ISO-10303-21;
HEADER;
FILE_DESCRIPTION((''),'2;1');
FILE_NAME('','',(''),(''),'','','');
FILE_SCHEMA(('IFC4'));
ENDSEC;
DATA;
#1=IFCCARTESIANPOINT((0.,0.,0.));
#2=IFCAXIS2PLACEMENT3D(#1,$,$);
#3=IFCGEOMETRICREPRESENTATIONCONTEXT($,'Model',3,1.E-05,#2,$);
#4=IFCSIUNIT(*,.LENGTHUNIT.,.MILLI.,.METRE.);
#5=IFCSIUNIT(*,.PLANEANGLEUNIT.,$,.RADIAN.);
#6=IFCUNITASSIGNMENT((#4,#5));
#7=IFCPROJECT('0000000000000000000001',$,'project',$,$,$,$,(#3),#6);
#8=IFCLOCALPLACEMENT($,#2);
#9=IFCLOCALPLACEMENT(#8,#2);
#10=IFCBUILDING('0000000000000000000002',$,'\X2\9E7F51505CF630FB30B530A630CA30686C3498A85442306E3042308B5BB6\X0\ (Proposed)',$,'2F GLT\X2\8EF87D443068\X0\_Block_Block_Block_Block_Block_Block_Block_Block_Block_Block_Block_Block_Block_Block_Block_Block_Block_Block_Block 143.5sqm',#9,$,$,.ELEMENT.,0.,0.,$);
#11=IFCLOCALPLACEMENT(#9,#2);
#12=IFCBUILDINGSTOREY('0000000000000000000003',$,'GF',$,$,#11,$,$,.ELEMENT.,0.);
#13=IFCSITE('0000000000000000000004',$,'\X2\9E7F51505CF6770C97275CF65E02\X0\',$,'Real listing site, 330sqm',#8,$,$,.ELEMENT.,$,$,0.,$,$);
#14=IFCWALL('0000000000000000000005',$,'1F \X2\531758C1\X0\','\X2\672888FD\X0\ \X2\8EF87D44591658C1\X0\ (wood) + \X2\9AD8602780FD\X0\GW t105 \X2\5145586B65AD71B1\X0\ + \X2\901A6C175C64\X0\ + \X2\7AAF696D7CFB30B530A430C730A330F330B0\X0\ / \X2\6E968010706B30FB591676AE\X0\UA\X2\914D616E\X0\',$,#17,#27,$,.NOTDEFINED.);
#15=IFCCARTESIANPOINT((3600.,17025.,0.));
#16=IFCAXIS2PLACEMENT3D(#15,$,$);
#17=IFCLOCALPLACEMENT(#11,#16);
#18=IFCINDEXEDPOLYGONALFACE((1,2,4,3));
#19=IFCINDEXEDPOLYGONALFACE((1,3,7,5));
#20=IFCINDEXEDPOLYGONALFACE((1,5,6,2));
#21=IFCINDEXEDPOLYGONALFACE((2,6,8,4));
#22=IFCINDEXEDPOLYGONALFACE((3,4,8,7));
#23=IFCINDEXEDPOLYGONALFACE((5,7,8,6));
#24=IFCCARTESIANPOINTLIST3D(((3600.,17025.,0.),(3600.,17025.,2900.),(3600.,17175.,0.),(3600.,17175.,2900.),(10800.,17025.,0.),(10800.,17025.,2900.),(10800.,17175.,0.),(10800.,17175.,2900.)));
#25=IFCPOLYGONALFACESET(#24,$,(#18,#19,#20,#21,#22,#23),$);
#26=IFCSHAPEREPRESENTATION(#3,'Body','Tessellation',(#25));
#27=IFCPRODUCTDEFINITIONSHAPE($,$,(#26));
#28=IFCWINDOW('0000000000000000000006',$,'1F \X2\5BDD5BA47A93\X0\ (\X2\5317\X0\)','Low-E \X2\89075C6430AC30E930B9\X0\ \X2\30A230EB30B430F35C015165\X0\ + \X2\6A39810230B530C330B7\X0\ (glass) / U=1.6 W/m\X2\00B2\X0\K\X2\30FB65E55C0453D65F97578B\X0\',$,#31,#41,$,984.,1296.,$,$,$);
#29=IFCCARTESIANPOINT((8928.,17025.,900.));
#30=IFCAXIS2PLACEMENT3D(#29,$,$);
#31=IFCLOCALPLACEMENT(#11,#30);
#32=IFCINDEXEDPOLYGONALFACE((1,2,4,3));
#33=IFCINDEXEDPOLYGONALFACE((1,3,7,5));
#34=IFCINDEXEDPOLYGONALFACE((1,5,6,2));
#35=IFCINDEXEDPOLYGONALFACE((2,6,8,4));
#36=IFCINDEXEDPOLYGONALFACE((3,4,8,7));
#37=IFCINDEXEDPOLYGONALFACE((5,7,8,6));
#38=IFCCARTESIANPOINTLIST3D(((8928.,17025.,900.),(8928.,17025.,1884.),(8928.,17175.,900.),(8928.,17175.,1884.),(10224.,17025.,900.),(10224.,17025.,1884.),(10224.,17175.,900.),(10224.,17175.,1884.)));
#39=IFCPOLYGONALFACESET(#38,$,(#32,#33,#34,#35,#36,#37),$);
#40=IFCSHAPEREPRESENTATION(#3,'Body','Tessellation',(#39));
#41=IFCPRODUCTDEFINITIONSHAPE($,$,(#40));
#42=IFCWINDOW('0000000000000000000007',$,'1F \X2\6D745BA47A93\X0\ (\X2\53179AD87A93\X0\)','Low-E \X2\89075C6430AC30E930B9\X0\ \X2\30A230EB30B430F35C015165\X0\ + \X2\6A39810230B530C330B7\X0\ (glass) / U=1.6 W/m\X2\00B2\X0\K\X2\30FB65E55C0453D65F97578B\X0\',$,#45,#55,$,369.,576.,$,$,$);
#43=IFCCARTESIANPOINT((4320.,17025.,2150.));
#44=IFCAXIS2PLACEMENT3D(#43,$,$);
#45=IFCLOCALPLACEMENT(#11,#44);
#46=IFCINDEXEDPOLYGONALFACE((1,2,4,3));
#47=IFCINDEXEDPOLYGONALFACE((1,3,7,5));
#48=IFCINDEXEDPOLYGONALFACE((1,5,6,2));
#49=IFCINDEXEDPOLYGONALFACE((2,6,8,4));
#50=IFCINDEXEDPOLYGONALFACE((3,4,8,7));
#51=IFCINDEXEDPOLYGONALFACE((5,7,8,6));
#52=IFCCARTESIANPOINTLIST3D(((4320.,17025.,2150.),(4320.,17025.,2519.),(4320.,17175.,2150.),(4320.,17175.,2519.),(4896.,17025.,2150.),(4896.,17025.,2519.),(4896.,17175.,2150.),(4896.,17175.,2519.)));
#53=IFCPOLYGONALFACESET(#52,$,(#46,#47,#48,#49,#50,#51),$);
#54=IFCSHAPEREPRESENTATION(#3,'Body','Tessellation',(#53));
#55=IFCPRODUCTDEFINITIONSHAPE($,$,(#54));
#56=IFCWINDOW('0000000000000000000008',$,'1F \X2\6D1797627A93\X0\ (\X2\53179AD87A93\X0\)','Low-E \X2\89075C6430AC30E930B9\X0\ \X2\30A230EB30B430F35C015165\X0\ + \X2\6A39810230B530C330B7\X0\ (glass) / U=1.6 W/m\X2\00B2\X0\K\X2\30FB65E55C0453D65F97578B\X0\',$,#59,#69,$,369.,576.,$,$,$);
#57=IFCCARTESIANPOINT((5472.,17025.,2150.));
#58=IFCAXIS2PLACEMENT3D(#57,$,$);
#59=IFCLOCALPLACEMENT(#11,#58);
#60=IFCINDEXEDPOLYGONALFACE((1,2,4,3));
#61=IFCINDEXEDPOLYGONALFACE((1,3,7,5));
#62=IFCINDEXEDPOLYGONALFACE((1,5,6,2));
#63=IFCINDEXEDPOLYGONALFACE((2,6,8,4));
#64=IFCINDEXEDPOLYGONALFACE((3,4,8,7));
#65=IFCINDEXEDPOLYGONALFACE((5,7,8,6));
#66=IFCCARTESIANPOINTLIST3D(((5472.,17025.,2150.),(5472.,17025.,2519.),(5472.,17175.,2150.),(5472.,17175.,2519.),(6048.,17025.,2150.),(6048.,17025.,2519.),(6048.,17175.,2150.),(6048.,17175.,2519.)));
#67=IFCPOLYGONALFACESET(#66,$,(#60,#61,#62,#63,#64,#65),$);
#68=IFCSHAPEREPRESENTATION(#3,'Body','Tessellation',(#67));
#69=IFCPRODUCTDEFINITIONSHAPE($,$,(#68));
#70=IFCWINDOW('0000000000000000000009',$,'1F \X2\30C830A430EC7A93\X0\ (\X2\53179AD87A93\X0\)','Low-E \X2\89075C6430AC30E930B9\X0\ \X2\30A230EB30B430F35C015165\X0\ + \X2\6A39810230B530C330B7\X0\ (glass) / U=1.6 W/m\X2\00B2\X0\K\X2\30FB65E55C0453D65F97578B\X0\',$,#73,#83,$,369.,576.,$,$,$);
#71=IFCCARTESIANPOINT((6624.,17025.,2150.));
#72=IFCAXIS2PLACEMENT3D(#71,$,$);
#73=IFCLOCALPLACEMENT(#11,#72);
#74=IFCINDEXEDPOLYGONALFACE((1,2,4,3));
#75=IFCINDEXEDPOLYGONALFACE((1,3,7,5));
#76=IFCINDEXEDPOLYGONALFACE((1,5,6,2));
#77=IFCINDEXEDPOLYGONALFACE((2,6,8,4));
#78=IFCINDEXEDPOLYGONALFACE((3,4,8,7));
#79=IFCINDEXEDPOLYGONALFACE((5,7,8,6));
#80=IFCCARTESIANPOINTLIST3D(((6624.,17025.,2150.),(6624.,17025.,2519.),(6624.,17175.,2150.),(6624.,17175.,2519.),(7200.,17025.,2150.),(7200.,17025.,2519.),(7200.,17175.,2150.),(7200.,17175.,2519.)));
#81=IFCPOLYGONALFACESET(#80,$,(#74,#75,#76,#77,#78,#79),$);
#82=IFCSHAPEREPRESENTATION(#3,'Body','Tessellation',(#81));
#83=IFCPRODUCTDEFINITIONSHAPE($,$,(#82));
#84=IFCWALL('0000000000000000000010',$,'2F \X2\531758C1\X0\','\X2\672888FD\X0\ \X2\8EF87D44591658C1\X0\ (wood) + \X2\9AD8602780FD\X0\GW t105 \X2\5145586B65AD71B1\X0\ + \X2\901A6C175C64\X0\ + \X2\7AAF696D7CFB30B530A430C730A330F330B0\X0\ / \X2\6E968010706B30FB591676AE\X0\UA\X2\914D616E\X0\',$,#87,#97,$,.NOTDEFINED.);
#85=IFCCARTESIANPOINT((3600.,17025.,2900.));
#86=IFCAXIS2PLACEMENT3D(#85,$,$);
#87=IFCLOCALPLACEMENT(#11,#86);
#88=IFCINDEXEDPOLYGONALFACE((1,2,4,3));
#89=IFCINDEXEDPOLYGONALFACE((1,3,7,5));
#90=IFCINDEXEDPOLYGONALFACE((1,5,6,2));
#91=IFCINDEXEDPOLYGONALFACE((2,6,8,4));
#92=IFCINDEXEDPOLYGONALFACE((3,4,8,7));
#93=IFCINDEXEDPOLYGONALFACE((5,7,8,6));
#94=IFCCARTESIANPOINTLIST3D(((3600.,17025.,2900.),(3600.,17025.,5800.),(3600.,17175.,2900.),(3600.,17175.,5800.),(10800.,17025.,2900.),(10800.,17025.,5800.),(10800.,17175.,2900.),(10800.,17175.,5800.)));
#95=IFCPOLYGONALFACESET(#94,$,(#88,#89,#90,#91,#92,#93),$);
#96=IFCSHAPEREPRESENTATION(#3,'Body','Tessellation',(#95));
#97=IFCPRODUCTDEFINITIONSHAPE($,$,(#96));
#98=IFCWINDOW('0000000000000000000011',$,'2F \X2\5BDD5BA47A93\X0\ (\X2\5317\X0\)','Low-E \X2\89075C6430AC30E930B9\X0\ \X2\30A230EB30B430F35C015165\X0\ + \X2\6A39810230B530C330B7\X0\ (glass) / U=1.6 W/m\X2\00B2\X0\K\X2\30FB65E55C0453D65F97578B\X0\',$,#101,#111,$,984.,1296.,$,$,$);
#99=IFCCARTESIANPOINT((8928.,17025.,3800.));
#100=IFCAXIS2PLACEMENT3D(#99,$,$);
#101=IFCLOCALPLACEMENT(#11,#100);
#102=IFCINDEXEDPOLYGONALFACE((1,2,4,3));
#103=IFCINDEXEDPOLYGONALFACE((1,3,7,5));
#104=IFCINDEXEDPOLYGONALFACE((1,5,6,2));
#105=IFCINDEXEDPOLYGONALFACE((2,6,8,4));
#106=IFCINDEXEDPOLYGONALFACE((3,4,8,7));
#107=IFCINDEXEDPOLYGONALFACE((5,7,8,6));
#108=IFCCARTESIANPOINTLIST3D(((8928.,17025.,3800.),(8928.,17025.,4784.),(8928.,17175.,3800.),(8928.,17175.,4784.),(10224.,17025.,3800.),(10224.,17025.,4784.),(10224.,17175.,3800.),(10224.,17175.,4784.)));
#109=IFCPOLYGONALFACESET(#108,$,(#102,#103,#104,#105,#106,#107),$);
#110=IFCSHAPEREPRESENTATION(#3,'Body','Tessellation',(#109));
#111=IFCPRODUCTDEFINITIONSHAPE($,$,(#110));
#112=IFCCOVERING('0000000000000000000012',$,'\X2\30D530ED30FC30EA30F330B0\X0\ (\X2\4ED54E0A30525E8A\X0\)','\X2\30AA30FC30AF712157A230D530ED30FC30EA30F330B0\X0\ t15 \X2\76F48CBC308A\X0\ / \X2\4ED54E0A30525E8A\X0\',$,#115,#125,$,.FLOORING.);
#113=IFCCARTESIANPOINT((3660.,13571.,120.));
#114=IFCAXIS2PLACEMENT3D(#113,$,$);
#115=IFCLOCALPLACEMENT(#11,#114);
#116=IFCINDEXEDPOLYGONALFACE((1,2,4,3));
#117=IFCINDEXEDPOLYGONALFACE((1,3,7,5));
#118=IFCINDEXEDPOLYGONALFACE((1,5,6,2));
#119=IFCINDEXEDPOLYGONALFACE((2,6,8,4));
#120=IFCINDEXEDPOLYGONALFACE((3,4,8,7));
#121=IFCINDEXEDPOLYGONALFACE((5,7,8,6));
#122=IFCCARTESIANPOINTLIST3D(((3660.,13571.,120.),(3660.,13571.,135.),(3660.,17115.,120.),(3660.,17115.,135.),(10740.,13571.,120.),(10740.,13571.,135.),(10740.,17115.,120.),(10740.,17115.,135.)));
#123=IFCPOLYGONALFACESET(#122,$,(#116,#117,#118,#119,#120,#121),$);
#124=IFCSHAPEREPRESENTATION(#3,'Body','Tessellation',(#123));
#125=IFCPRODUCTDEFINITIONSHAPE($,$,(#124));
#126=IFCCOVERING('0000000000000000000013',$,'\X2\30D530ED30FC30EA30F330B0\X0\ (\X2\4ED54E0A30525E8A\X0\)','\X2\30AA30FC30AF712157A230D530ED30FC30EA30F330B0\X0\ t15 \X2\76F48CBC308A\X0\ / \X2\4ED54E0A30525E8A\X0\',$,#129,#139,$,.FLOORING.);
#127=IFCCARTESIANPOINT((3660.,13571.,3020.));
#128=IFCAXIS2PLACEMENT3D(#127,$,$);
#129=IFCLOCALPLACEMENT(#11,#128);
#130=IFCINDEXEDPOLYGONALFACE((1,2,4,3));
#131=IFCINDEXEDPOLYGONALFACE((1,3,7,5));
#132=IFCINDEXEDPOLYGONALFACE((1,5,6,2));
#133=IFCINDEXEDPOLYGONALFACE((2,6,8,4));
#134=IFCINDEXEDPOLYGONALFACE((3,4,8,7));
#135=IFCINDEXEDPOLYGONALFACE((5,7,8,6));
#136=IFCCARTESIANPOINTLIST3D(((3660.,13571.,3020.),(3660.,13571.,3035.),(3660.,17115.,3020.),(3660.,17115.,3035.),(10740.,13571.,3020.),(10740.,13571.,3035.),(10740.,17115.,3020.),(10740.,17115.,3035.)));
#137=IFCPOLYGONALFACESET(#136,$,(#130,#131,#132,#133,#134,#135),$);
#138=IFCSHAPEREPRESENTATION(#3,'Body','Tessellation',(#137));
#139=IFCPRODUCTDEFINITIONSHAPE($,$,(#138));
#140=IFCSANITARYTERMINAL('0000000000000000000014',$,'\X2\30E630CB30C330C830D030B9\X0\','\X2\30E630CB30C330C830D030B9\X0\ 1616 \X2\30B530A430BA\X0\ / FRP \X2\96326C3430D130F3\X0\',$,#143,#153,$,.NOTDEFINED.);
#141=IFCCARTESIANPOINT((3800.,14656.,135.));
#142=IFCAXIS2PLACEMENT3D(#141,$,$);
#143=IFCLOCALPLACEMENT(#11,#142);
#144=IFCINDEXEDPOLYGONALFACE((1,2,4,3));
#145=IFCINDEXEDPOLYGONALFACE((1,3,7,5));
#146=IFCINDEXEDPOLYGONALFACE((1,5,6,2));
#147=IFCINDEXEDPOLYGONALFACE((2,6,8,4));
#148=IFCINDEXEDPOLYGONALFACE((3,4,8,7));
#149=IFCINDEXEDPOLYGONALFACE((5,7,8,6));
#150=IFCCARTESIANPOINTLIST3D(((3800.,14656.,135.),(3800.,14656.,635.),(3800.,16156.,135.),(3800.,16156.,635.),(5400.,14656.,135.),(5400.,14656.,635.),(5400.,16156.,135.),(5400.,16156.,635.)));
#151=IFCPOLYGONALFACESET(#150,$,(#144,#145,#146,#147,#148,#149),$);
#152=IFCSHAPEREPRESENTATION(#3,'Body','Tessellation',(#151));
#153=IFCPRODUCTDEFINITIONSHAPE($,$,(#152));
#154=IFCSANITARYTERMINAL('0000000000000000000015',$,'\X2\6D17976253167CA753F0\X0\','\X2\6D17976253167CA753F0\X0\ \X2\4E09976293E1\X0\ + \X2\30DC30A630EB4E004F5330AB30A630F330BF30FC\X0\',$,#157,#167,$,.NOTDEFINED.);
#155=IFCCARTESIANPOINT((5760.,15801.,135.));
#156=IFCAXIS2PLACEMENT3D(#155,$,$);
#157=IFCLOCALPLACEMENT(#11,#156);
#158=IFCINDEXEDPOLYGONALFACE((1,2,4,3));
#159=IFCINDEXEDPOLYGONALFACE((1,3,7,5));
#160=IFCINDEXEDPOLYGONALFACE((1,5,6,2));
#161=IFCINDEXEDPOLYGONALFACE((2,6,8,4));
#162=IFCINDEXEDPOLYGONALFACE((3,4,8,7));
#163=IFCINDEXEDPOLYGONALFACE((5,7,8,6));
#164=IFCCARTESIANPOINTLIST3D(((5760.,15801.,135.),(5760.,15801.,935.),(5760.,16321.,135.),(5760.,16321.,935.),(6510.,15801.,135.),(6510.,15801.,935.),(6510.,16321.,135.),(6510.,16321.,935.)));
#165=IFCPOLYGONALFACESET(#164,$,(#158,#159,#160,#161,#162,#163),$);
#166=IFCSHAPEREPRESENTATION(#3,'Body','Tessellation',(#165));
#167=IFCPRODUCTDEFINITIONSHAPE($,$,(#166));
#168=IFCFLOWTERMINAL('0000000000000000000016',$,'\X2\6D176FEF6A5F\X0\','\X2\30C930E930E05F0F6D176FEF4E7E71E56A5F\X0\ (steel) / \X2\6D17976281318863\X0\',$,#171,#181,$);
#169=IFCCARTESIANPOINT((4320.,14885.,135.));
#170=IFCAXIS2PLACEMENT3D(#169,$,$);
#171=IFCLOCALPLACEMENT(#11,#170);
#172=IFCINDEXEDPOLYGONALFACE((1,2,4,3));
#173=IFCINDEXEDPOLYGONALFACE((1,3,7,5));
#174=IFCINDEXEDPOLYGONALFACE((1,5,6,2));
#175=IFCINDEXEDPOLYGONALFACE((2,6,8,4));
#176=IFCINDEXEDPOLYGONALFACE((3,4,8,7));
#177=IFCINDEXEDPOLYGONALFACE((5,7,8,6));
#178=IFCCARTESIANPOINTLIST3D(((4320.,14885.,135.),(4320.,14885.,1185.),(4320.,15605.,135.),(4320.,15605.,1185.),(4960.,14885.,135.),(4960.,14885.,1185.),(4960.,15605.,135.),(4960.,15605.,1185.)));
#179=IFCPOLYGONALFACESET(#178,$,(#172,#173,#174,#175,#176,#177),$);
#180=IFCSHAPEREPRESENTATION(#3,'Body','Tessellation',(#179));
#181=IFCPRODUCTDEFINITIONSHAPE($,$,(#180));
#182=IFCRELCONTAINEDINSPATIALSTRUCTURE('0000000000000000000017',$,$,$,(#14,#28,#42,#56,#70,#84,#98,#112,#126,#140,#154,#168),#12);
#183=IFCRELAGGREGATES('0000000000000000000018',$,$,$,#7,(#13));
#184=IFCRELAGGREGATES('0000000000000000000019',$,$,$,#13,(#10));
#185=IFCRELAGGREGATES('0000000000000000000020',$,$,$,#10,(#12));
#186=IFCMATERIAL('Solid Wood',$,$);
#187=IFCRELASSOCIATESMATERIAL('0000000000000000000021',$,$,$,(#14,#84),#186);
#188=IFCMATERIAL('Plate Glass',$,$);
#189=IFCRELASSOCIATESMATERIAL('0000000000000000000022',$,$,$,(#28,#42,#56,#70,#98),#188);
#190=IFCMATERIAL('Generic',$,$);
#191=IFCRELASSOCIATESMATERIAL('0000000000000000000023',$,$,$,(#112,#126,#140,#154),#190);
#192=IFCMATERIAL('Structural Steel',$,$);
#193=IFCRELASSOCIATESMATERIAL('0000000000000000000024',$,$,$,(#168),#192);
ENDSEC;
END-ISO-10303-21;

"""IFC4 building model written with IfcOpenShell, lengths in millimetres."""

from ifc_helpers import new_model, si_unit, frame, frame_2d, origin, place, context, project, spatial, rectangle, extrude, material, element, fill, save


model = new_model("IFC4")

# Units and contexts
model_context = context("Model", 3, precision=1e-05, world=origin())
ifc_project = project(units=[si_unit("LENGTHUNIT", "METRE", prefix="MILLI"), si_unit("PLANEANGLEUNIT", "RADIAN")], contexts=[model_context])

# Site, building, storey
site_placement = place(None, origin())
site = spatial("IfcSite", under=ifc_project, at=site_placement, Name="鹿児島県霧島市", ObjectType="Real listing site, 330sqm", CompositionType="ELEMENT", RefElevation=0.0)
building_placement = place(site_placement, origin())
building = spatial("IfcBuilding", under=site, at=building_placement, Name="鹿児島・サウナと水風呂のある家 (Proposed)", ObjectType="2F GLT軸組と_Block_Block_Block_Block_Block_Block_Block_Block_Block_Block_Block_Block_Block_Block_Block_Block_Block_Block_Block 143.5sqm", CompositionType="ELEMENT", ElevationOfRefHeight=0.0, ElevationOfTerrain=0.0)
storey_placement = place(building_placement, origin())
storey = spatial("IfcBuildingStorey", under=building, at=storey_placement, Name="GF", CompositionType="ELEMENT", Elevation=0.0)

# Shared definitions
ifc_material_1 = material(Name="Solid Wood")

# Wall, openings, windows
wall_1_placement = place(storey_placement, frame((3600.0, 17025.0, 0.0)))
wall_1 = element("IfcWall", 1, at=wall_1_placement, inside=storey, material=ifc_material_1, Name="1F 北壁", Description="木製 軸組外壁 (wood) + 高性能GW t105 充填断熱 + 通気層 + 窯業系サイディング / 準耐火・外皮UA配慮", PredefinedType="NOTDEFINED", context=model_context, shape_type="SweptSolid", body=[
    extrude(rectangle(XDim=7200.0, YDim=150.0, at=frame_2d((3600.0, 75.0))), frame((3600.0, 17025.0, 0.0)), (0.0, 0.0, 1.0), 2900.0),
])
opening_1_placement = place(storey_placement, frame((8928.0, 17025.0, 900.0)))
opening_1 = element("IfcOpeningElement", 2, at=opening_1_placement, cuts=wall_1, PredefinedType="NOTDEFINED", context=model_context, shape_type="SweptSolid", body=[
    extrude(rectangle(XDim=1296.0, YDim=150.0, at=frame_2d((648.0, 75.0))), frame((8928.0, 17025.0, 900.0)), (0.0, 0.0, 1.0), 984.0),
])
opening_2_placement = place(storey_placement, frame((4320.0, 17025.0, 2150.0)))
opening_2 = element("IfcOpeningElement", 3, at=opening_2_placement, cuts=wall_1, PredefinedType="NOTDEFINED", context=model_context, shape_type="SweptSolid", body=[
    extrude(rectangle(XDim=576.0, YDim=150.0, at=frame_2d((288.0, 75.0))), frame((4320.0, 17025.0, 2150.0)), (0.0, 0.0, 1.0), 369.0),
])
opening_3_placement = place(storey_placement, frame((5472.0, 17025.0, 2150.0)))
opening_3 = element("IfcOpeningElement", 4, at=opening_3_placement, cuts=wall_1, PredefinedType="NOTDEFINED", context=model_context, shape_type="SweptSolid", body=[
    extrude(rectangle(XDim=576.0, YDim=150.0, at=frame_2d((288.0, 75.0))), frame((5472.0, 17025.0, 2150.0)), (0.0, 0.0, 1.0), 369.0),
])
opening_4_placement = place(storey_placement, frame((6624.0, 17025.0, 2150.0)))
opening_4 = element("IfcOpeningElement", 5, at=opening_4_placement, cuts=wall_1, PredefinedType="NOTDEFINED", context=model_context, shape_type="SweptSolid", body=[
    extrude(rectangle(XDim=576.0, YDim=150.0, at=frame_2d((288.0, 75.0))), frame((6624.0, 17025.0, 2150.0)), (0.0, 0.0, 1.0), 369.0),
])
ifc_material_2 = material(Name="Plate Glass")
window_1_placement = place(storey_placement, frame((8928.0, 17025.0, 900.0)))
window_1 = element("IfcWindow", 6, at=window_1_placement, inside=storey, material=ifc_material_2, Name="1F 寝室窓 (北)", Description="Low-E 複層ガラス アルゴン封入 + 樹脂サッシ (glass) / U=1.6 W/m²K・日射取得型", OverallHeight=984.0, OverallWidth=1296.0, context=model_context, shape_type="SweptSolid", body=[
    extrude(rectangle(XDim=1296.0, YDim=150.0, at=frame_2d((648.0, 75.0))), frame((8928.0, 17025.0, 900.0)), (0.0, 0.0, 1.0), 984.0),
])
fill(opening_1, window_1)
window_2_placement = place(storey_placement, frame((4320.0, 17025.0, 2150.0)))
window_2 = element("IfcWindow", 7, at=window_2_placement, inside=storey, material=ifc_material_2, Name="1F 浴室窓 (北高窓)", Description="Low-E 複層ガラス アルゴン封入 + 樹脂サッシ (glass) / U=1.6 W/m²K・日射取得型", OverallHeight=369.0, OverallWidth=576.0, context=model_context, shape_type="SweptSolid", body=[
    extrude(rectangle(XDim=576.0, YDim=150.0, at=frame_2d((288.0, 75.0))), frame((4320.0, 17025.0, 2150.0)), (0.0, 0.0, 1.0), 369.0),
])
fill(opening_2, window_2)
window_3_placement = place(storey_placement, frame((5472.0, 17025.0, 2150.0)))
window_3 = element("IfcWindow", 8, at=window_3_placement, inside=storey, material=ifc_material_2, Name="1F 洗面窓 (北高窓)", Description="Low-E 複層ガラス アルゴン封入 + 樹脂サッシ (glass) / U=1.6 W/m²K・日射取得型", OverallHeight=369.0, OverallWidth=576.0, context=model_context, shape_type="SweptSolid", body=[
    extrude(rectangle(XDim=576.0, YDim=150.0, at=frame_2d((288.0, 75.0))), frame((5472.0, 17025.0, 2150.0)), (0.0, 0.0, 1.0), 369.0),
])
fill(opening_3, window_3)
window_4_placement = place(storey_placement, frame((6624.0, 17025.0, 2150.0)))
window_4 = element("IfcWindow", 9, at=window_4_placement, inside=storey, material=ifc_material_2, Name="1F トイレ窓 (北高窓)", Description="Low-E 複層ガラス アルゴン封入 + 樹脂サッシ (glass) / U=1.6 W/m²K・日射取得型", OverallHeight=369.0, OverallWidth=576.0, context=model_context, shape_type="SweptSolid", body=[
    extrude(rectangle(XDim=576.0, YDim=150.0, at=frame_2d((288.0, 75.0))), frame((6624.0, 17025.0, 2150.0)), (0.0, 0.0, 1.0), 369.0),
])
fill(opening_4, window_4)

# Wall, opening, window
wall_2_placement = place(storey_placement, frame((3600.0, 17025.0, 2900.0)))
wall_2 = element("IfcWall", 10, at=wall_2_placement, inside=storey, material=ifc_material_1, Name="2F 北壁", Description="木製 軸組外壁 (wood) + 高性能GW t105 充填断熱 + 通気層 + 窯業系サイディング / 準耐火・外皮UA配慮", PredefinedType="NOTDEFINED", context=model_context, shape_type="SweptSolid", body=[
    extrude(rectangle(XDim=7200.0, YDim=150.0, at=frame_2d((3600.0, 75.0))), frame((3600.0, 17025.0, 2900.0)), (0.0, 0.0, 1.0), 2900.0),
])
opening_5_placement = place(storey_placement, frame((8928.0, 17025.0, 3800.0)))
opening_5 = element("IfcOpeningElement", 11, at=opening_5_placement, cuts=wall_2, PredefinedType="NOTDEFINED", context=model_context, shape_type="SweptSolid", body=[
    extrude(rectangle(XDim=1296.0, YDim=150.0, at=frame_2d((648.0, 75.0))), frame((8928.0, 17025.0, 3800.0)), (0.0, 0.0, 1.0), 984.0),
])
window_5_placement = place(storey_placement, frame((8928.0, 17025.0, 3800.0)))
window_5 = element("IfcWindow", 12, at=window_5_placement, inside=storey, material=ifc_material_2, Name="2F 寝室窓 (北)", Description="Low-E 複層ガラス アルゴン封入 + 樹脂サッシ (glass) / U=1.6 W/m²K・日射取得型", OverallHeight=984.0, OverallWidth=1296.0, context=model_context, shape_type="SweptSolid", body=[
    extrude(rectangle(XDim=1296.0, YDim=150.0, at=frame_2d((648.0, 75.0))), frame((8928.0, 17025.0, 3800.0)), (0.0, 0.0, 1.0), 984.0),
])
fill(opening_5, window_5)

# Coverings
ifc_material_3 = material(Name="Generic")
covering_1_placement = place(storey_placement, frame((3660.0, 13571.0, 120.0)))
element("IfcCovering", 13, at=covering_1_placement, inside=storey, material=ifc_material_3, Name="フローリング (仕上げ床)", Description="オーク無垢フローリング t15 直貼り / 仕上げ床", PredefinedType="FLOORING", context=model_context, shape_type="SweptSolid", body=[
    extrude(rectangle(XDim=7080.0, YDim=3544.0, at=frame_2d((3540.0, 1772.0))), frame((3660.0, 13571.0, 120.0)), (0.0, 0.0, 1.0), 15.0),
])
covering_2_placement = place(storey_placement, frame((3660.0, 13571.0, 3020.0)))
element("IfcCovering", 14, at=covering_2_placement, inside=storey, material=ifc_material_3, Name="フローリング (仕上げ床)", Description="オーク無垢フローリング t15 直貼り / 仕上げ床", PredefinedType="FLOORING", context=model_context, shape_type="SweptSolid", body=[
    extrude(rectangle(XDim=7080.0, YDim=3544.0, at=frame_2d((3540.0, 1772.0))), frame((3660.0, 13571.0, 3020.0)), (0.0, 0.0, 1.0), 15.0),
])

# Sanitary terminals
sanitary_terminal_1_placement = place(storey_placement, frame((3800.0, 14656.0, 135.0)))
element("IfcSanitaryTerminal", 15, at=sanitary_terminal_1_placement, inside=storey, material=ifc_material_3, Name="ユニットバス", Description="ユニットバス 1616 サイズ / FRP 防水パン", PredefinedType="NOTDEFINED", context=model_context, shape_type="SweptSolid", body=[
    extrude(rectangle(XDim=1600.0, YDim=1500.0, at=frame_2d((800.0, 750.0))), frame((3800.0, 14656.0, 135.0)), (0.0, 0.0, 1.0), 500.0),
])
sanitary_terminal_2_placement = place(storey_placement, frame((5760.0, 15801.0, 135.0)))
element("IfcSanitaryTerminal", 16, at=sanitary_terminal_2_placement, inside=storey, material=ifc_material_3, Name="洗面化粧台", Description="洗面化粧台 三面鏡 + ボウル一体カウンター", PredefinedType="NOTDEFINED", context=model_context, shape_type="SweptSolid", body=[
    extrude(rectangle(XDim=750.0, YDim=520.0, at=frame_2d((375.0, 260.0))), frame((5760.0, 15801.0, 135.0)), (0.0, 0.0, 1.0), 800.0),
])

# Flow terminal
ifc_material_4 = material(Name="Structural Steel")
flow_terminal_placement = place(storey_placement, frame((4320.0, 14885.0, 135.0)))
element("IfcFlowTerminal", 17, at=flow_terminal_placement, inside=storey, material=ifc_material_4, Name="洗濯機", Description="ドラム式洗濯乾燥機 (steel) / 洗面脱衣", context=model_context, shape_type="SweptSolid", body=[
    extrude(rectangle(XDim=640.0, YDim=720.0, at=frame_2d((320.0, 360.0))), frame((4320.0, 14885.0, 135.0)), (0.0, 0.0, 1.0), 1050.0),
])

save(model, "model.ifc")
